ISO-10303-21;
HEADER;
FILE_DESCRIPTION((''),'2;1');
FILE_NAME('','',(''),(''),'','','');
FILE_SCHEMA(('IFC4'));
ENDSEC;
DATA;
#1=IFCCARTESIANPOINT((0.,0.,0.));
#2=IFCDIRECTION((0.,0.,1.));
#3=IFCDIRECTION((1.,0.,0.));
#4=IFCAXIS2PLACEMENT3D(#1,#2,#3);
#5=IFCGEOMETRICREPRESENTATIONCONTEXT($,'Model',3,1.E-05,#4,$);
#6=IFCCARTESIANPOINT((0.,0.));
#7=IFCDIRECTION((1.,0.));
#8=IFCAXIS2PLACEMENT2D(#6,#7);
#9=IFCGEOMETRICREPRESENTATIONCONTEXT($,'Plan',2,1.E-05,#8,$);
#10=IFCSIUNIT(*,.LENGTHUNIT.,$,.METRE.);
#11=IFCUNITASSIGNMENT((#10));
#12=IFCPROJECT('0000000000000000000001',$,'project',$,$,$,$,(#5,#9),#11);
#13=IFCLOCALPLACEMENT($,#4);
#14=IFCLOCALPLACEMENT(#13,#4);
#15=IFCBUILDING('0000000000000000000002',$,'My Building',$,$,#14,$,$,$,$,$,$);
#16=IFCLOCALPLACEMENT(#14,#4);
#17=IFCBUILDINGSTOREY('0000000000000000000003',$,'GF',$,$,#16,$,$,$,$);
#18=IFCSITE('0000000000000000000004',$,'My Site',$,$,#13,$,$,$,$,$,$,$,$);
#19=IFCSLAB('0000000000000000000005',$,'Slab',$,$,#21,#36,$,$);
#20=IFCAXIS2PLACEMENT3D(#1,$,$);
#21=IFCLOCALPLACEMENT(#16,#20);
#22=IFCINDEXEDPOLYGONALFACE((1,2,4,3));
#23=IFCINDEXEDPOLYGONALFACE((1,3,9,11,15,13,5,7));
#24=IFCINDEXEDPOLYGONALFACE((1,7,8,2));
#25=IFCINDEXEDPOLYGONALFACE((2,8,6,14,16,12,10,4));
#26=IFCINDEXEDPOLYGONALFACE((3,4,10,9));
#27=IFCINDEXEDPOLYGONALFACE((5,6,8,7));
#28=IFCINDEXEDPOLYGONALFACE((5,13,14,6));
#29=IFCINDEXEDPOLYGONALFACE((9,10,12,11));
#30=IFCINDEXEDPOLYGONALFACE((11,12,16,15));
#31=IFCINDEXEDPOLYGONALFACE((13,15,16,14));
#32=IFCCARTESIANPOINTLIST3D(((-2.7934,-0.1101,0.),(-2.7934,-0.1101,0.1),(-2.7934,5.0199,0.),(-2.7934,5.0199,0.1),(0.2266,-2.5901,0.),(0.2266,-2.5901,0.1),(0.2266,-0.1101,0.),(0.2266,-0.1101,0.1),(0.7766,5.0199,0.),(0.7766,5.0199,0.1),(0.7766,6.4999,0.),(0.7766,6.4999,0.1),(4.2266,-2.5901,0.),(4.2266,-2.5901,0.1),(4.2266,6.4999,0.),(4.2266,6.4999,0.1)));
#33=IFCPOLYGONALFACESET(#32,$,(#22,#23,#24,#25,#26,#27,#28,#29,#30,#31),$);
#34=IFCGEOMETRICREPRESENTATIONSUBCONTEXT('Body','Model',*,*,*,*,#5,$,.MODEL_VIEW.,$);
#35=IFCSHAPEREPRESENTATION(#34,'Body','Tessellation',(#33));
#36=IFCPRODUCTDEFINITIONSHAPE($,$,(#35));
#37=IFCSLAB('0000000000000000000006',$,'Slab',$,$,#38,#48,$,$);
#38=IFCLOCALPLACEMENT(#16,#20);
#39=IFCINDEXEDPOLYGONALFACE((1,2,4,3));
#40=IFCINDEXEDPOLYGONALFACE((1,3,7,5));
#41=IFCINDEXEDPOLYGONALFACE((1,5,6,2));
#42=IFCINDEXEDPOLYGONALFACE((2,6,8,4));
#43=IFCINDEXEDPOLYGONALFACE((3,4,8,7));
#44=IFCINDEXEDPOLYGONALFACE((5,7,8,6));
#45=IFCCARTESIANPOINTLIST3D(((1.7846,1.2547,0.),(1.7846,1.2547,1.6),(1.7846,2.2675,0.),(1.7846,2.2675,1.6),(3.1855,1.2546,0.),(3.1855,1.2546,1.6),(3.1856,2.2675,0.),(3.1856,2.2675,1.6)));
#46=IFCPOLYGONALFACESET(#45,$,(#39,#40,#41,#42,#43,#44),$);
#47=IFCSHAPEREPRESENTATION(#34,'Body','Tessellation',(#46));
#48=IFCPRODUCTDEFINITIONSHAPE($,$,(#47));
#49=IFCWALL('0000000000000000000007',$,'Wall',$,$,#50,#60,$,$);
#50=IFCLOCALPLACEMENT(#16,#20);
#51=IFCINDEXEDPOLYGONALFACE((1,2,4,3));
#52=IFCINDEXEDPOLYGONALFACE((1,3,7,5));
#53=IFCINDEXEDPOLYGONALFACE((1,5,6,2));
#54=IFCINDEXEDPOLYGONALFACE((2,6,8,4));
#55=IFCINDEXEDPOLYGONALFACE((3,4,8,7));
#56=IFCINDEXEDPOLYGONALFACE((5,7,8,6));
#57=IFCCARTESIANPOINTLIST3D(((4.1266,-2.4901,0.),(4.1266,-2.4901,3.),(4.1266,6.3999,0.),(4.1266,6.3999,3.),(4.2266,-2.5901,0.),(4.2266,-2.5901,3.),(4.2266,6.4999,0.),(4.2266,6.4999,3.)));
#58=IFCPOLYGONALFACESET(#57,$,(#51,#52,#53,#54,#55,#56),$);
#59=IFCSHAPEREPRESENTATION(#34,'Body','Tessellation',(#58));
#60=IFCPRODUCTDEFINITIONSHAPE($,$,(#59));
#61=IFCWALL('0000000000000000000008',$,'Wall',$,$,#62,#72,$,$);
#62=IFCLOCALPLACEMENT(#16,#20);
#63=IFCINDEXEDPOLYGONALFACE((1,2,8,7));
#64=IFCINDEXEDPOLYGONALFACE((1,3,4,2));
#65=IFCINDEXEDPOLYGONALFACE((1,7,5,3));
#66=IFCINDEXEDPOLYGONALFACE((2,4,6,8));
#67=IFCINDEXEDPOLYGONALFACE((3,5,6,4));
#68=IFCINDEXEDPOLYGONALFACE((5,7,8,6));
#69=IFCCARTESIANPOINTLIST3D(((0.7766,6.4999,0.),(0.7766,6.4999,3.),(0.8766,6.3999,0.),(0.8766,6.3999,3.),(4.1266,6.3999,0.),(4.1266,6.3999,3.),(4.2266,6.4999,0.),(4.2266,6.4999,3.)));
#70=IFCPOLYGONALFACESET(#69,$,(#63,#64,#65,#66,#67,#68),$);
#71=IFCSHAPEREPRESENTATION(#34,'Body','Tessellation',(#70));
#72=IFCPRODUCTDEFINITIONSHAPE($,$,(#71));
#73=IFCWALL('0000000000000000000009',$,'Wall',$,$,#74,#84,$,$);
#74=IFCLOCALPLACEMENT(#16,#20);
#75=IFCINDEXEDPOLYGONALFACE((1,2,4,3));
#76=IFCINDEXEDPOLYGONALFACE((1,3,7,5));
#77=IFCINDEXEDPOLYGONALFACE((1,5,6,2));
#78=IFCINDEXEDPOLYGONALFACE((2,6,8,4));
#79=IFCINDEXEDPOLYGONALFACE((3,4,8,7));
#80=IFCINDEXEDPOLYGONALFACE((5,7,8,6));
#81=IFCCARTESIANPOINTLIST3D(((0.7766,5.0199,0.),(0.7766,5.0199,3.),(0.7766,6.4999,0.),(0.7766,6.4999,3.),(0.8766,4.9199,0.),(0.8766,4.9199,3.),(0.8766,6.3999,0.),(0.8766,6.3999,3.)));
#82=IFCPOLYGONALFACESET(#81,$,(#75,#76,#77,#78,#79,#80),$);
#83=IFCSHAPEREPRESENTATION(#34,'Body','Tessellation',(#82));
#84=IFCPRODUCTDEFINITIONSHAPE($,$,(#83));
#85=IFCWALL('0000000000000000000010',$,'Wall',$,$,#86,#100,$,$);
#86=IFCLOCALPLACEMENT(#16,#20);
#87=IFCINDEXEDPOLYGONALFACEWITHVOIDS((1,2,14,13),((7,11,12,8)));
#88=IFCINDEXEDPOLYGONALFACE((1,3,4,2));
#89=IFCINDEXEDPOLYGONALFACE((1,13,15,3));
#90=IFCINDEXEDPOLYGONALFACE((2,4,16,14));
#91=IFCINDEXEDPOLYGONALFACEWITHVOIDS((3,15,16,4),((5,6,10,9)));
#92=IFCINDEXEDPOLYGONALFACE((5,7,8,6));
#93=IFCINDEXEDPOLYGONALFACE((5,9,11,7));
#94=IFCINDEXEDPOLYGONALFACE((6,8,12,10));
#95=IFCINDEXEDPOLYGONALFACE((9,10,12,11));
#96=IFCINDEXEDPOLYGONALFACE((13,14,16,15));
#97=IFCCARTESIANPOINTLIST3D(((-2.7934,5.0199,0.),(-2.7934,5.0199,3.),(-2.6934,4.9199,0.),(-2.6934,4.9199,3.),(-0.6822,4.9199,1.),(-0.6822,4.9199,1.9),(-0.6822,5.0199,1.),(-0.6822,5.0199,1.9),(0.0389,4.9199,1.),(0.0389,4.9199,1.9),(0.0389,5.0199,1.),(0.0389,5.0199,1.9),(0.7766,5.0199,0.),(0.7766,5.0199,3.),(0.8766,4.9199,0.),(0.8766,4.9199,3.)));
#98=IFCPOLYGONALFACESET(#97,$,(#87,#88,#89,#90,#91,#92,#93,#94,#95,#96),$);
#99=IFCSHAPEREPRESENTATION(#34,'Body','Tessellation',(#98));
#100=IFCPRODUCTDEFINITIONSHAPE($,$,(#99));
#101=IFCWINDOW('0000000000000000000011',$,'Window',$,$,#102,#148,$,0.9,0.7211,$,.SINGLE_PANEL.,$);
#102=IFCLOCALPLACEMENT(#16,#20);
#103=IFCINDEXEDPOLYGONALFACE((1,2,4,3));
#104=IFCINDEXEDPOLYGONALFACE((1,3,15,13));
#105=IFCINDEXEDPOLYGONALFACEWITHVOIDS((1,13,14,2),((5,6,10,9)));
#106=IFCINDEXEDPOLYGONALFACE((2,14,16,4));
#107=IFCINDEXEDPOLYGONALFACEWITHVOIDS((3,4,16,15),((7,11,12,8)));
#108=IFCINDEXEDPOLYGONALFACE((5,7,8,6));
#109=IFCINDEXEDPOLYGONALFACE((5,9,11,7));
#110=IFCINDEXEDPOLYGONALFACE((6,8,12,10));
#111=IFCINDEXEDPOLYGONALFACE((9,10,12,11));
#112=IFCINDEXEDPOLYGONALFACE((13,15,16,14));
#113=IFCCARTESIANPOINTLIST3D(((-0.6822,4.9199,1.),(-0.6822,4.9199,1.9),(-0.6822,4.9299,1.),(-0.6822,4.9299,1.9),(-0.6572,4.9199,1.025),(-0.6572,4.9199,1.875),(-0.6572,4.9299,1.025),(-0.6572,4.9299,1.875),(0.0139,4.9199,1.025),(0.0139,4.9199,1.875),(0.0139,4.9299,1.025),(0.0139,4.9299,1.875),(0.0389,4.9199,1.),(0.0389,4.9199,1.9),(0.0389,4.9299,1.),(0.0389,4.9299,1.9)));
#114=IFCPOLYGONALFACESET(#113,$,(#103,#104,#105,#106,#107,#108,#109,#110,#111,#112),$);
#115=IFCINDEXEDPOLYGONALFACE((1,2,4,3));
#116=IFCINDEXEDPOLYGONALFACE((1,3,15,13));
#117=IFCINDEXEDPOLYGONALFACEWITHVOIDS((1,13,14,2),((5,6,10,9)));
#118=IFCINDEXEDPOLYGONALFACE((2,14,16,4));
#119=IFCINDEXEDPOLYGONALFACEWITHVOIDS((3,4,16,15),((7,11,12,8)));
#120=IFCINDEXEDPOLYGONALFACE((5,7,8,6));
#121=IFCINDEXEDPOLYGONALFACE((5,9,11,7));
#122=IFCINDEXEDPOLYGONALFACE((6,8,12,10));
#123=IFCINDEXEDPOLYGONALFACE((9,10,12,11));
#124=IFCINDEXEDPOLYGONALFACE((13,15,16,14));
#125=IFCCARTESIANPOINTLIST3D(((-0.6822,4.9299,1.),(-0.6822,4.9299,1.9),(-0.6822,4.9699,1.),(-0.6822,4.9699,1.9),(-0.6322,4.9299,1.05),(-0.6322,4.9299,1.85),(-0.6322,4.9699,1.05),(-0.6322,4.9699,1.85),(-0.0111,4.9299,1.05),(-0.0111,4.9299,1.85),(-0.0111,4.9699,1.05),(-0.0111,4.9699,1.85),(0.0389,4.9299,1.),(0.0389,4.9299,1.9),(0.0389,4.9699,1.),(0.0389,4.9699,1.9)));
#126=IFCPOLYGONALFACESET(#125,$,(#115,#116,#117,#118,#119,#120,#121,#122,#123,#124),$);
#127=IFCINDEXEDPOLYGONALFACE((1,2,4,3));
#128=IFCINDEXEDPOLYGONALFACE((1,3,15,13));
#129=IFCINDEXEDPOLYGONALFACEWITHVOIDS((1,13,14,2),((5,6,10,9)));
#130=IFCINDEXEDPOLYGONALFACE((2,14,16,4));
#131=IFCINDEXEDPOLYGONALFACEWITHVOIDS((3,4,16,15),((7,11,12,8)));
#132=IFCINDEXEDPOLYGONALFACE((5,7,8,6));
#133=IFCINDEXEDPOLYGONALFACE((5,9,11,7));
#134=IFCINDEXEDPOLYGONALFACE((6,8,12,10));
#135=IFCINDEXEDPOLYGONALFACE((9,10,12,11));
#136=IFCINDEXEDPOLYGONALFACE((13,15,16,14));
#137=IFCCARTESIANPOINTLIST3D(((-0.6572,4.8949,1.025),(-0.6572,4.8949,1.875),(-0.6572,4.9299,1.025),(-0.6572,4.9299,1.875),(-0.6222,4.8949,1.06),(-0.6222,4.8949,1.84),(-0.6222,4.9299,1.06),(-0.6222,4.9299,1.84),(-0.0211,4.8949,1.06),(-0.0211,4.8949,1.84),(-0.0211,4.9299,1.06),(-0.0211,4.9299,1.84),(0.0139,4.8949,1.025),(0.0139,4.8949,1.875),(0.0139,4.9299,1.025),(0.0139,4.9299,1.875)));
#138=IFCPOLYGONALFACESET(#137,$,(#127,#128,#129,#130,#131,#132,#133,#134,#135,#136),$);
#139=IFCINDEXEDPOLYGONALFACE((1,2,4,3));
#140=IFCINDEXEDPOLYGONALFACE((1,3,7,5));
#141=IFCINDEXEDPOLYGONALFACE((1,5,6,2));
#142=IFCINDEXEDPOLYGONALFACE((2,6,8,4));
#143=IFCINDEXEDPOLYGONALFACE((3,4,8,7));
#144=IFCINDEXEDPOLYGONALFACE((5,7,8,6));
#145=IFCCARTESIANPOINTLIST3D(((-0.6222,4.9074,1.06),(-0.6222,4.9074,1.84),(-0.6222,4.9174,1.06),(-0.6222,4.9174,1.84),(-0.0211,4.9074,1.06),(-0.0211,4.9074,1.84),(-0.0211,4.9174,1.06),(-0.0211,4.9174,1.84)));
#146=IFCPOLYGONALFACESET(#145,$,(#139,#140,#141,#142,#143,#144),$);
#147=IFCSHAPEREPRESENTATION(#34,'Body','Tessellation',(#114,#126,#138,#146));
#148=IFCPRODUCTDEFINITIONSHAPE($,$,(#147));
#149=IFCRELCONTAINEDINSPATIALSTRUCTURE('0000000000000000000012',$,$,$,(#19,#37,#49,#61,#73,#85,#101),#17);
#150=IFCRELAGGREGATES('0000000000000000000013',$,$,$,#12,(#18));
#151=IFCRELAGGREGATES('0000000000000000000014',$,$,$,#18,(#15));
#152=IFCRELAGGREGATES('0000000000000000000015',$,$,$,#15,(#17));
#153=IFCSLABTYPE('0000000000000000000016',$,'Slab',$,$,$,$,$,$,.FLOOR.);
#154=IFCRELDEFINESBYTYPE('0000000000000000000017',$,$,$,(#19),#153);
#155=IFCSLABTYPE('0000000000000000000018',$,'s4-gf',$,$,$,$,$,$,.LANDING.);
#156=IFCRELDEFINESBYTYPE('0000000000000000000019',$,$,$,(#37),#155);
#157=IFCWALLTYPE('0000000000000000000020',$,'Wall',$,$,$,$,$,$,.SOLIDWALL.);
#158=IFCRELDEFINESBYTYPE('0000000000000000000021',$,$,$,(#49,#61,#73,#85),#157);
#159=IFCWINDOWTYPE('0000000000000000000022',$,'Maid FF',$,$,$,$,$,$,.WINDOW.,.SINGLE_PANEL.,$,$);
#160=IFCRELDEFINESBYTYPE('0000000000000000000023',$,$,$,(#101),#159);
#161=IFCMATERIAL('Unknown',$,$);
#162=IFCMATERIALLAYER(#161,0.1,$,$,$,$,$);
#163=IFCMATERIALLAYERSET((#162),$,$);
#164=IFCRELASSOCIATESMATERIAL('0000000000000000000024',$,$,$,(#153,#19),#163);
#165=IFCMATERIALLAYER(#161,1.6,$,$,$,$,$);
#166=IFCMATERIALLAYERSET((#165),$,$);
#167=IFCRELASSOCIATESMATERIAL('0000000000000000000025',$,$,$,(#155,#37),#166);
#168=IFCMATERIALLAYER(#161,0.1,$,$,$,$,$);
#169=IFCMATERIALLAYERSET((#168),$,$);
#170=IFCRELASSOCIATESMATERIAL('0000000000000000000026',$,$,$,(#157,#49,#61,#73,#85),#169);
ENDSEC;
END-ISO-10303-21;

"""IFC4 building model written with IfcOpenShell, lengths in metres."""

from ifc_helpers import new_model, entity, si_unit, frame, origin_with_axes, origin_2d_with_axis, place, context, subcontext, project, spatial, line, indexed_curve, outline, extrude, shape, source, transform, mapped, material, layer, layer_set, layer_usage, type_object, type_shapes, element, fill, save


model = new_model("IFC4")

# Units and contexts
model_context = context("Model", 3, precision=1e-05, world=origin_with_axes())
plan_context = context("Plan", 2, precision=1e-05, world=origin_2d_with_axis())
body_context_1 = subcontext(model_context, "Body", "Model", "MODEL_VIEW")
body_context_2 = subcontext(plan_context, "Body", "Plan", "PLAN_VIEW")
ifc_project = project(units=[si_unit("LENGTHUNIT", "METRE")], contexts=[model_context, plan_context])

# Site, building, storey
site_placement = place(None, origin_with_axes())
site = spatial("IfcSite", under=ifc_project, at=site_placement, Name="My Site")
building_placement = place(site_placement, origin_with_axes())
building = spatial("IfcBuilding", under=site, at=building_placement, Name="My Building")
storey_placement = place(building_placement, origin_with_axes())
storey = spatial("IfcBuildingStorey", under=building, at=storey_placement, Name="GF")

# Slabs
ifc_material_1 = material(Name="Unknown")
ifc_layer_1 = layer(ifc_material_1, 0.1)
ifc_layer_set_1 = layer_set([ifc_layer_1])
ifc_layer_usage_1 = layer_usage(ifc_layer_set_1, "AXIS3", "POSITIVE", -0.1)
slab_type_1 = type_object("IfcSlabType", Name="Slab", PredefinedType="FLOOR", material=ifc_layer_set_1)
slab_1_placement = place(storey_placement, frame((4.2266, -2.5901, 0.1), z_axis=(0.0, 0.0, 1.0), x_axis=(1.0, 0.0, 0.0)))
element("IfcSlab", 1, at=slab_1_placement, inside=storey, type_object=slab_type_1, material=ifc_layer_usage_1, Name="Slab", context=body_context_1, shape_type="SweptSolid", body=[
    extrude(outline(indexed_curve([(0.0, 0.0), (-4.0, 0.0), (-4.0, 2.48), (-7.02, 2.48), (-7.02, 7.61), (-3.45, 7.61), (-3.45, 9.09), (0.0, 9.09), (0.0, 0.0)])), frame((0.0, 0.0, -0.1), z_axis=(0.0, 0.0, 1.0), x_axis=(1.0, 0.0, 0.0)), (0.0, 0.0, 1.0), 0.1),
])
ifc_layer_2 = layer(ifc_material_1, 1.6)
ifc_layer_set_2 = layer_set([ifc_layer_2])
ifc_layer_usage_2 = layer_usage(ifc_layer_set_2, "AXIS3", "POSITIVE", -1.8)
slab_type_2 = type_object("IfcSlabType", Name="s4-gf", PredefinedType="LANDING", material=ifc_layer_set_2)
slab_2_placement = place(storey_placement, frame((3.1855, 1.2546, 1.8), z_axis=(0.0, 0.0, 1.0), x_axis=(1.0, 0.0, 0.0)))
element("IfcSlab", 2, at=slab_2_placement, inside=storey, type_object=slab_type_2, material=ifc_layer_usage_2, Name="Slab", context=body_context_1, shape_type="SweptSolid", body=[
    extrude(outline(indexed_curve([(0.0001, 1.0128), (-1.401, 1.0128), (-1.4009, 0.0001), (0.0, 0.0), (0.0001, 1.0128)])), frame((0.0, 0.0, -1.8), z_axis=(0.0, 0.0, 1.0), x_axis=(1.0, 0.0, 0.0)), (0.0, 0.0, 1.0), 1.6),
])

# Shared definitions
ifc_layer_3 = layer(ifc_material_1, 0.1)
ifc_layer_set_3 = layer_set([ifc_layer_3])
wall_type = type_object("IfcWallType", Name="Wall", PredefinedType="SOLIDWALL", material=ifc_layer_set_3)

# Walls
ifc_layer_usage_3 = layer_usage(ifc_layer_set_3, "AXIS2", "POSITIVE", 0.0)
wall_1_placement = place(storey_placement, frame((4.2266, -2.5901, 0.0), z_axis=(0.0, 0.0, 1.0), x_axis=(0.0, 1.0, 0.0)))
element("IfcWall", 3, at=wall_1_placement, inside=storey, type_object=wall_type, material=ifc_layer_usage_3, Name="Wall", context=body_context_1, shape_type="SweptSolid", body=[
    extrude(outline(indexed_curve([(0.0, 0.0), (0.1, 0.1), (8.99, 0.1), (9.09, 0.0)], segments=[line(1, 2, 3, 4, 1)])), origin_with_axes(), (0.0, 0.0, 1.0), 3.0),
])
ifc_layer_usage_4 = layer_usage(ifc_layer_set_3, "AXIS2", "POSITIVE", 0.0)
wall_2_placement = place(storey_placement, frame((4.2266, 6.4999, 0.0), z_axis=(0.0, 0.0, 1.0), x_axis=(-1.0, 0.0, 0.0)))
element("IfcWall", 4, at=wall_2_placement, inside=storey, type_object=wall_type, material=ifc_layer_usage_4, Name="Wall", context=body_context_1, shape_type="SweptSolid", body=[
    extrude(outline(indexed_curve([(0.0, 0.0), (0.1, 0.1), (3.35, 0.1), (3.45, 0.0)], segments=[line(1, 2, 3, 4, 1)])), origin_with_axes(), (0.0, 0.0, 1.0), 3.0),
])
ifc_layer_usage_5 = layer_usage(ifc_layer_set_3, "AXIS2", "POSITIVE", 0.0)
wall_3_placement = place(storey_placement, frame((0.7766, 6.4999, 0.0), z_axis=(0.0, 0.0, 1.0), x_axis=(0.0, -1.0, 0.0)))
element("IfcWall", 5, at=wall_3_placement, inside=storey, type_object=wall_type, material=ifc_layer_usage_5, Name="Wall", context=body_context_1, shape_type="SweptSolid", body=[
    extrude(outline(indexed_curve([(0.0, 0.0), (0.1, 0.1), (1.58, 0.1), (1.48, 0.0)], segments=[line(1, 2, 3, 4, 1)])), origin_with_axes(), (0.0, 0.0, 1.0), 3.0),
])

# Wall, opening, window
ifc_layer_usage_6 = layer_usage(ifc_layer_set_3, "AXIS2", "POSITIVE", 0.0)
wall_4_placement = place(storey_placement, frame((0.7766, 5.0199, 0.0), z_axis=(0.0, 0.0, 1.0), x_axis=(-1.0, 0.0, 0.0)))
wall_4 = element("IfcWall", 6, at=wall_4_placement, inside=storey, type_object=wall_type, material=ifc_layer_usage_6, Name="Wall", context=body_context_1, shape_type="SweptSolid", body=[
    extrude(outline(indexed_curve([(0.0, 0.0), (-0.1, 0.1), (3.47, 0.1), (3.57, 0.0)], segments=[line(1, 2, 3, 4, 1)])), origin_with_axes(), (0.0, 0.0, 1.0), 3.0),
])
shared_shape_1 = source(origin_with_axes(), body_context_1, "Body", "SweptSolid", [
    extrude(outline(indexed_curve([(0.0, 0.0), (0.7211, 0.0), (0.7211, 0.9), (0.0, 0.9)], segments=[line(1, 2, 3, 4, 1)])), frame((0.0, -0.6, 0.0), z_axis=(0.0, -1.0, 0.0), x_axis=(1.0, 0.0, 0.0)), (0.0, 0.0, -1.0), 1.2),
])
opening_1_placement = place(wall_4_placement, frame((0.7377, 0.0, 1.0), z_axis=(0.0, 0.0, 1.0), x_axis=(1.0, 0.0, 0.0)))
opening_1 = element("IfcOpeningElement", 7, at=opening_1_placement, cuts=wall_4, PredefinedType="OPENING", context=body_context_1, shape_type="MappedRepresentation", body=[
    mapped(shared_shape_1, transform((0.0, 0.0, 0.0), x_axis=(1.0, 0.0, 0.0), y_axis=(0.0, 1.0, 0.0), z_axis=(0.0, 0.0, 1.0), scale=1.0)),
])
window_type_1 = type_object("IfcWindowType", Name="Maid FF", PartitioningType="SINGLE_PANEL", PredefinedType="WINDOW")
shared_shape_2 = source(origin_with_axes(), body_context_1, "Body", "SweptSolid", [
    extrude(outline(indexed_curve([(0.0, 0.0), (0.7211, 0.0), (0.7211, 0.9), (0.0, 0.9)], segments=[line(1, 2, 3, 4, 1)]), holes=[indexed_curve([(0.025, 0.025), (0.6961, 0.025), (0.6961, 0.875), (0.025, 0.875)], segments=[line(1, 2, 3, 4, 1)])]), frame((0.0, 0.09, 0.0), z_axis=(0.0, -1.0, 0.0), x_axis=(1.0, 0.0, 0.0)), (0.0, 0.0, -1.0), 0.01),
    extrude(outline(indexed_curve([(0.0, 0.0), (0.7211, 0.0), (0.7211, 0.9), (0.0, 0.9)], segments=[line(1, 2, 3, 4, 1)]), holes=[indexed_curve([(0.05, 0.05), (0.6711, 0.05), (0.6711, 0.85), (0.05, 0.85)], segments=[line(1, 2, 3, 4, 1)])]), frame((0.0, 0.05, 0.0), z_axis=(0.0, -1.0, 0.0), x_axis=(1.0, 0.0, 0.0)), (0.0, 0.0, -1.0), 0.04),
    extrude(outline(indexed_curve([(0.0, 0.0), (0.6711, 0.0), (0.6711, 0.85), (0.0, 0.85)], segments=[line(1, 2, 3, 4, 1)]), holes=[indexed_curve([(0.035, 0.035), (0.6361, 0.035), (0.6361, 0.815), (0.035, 0.815)], segments=[line(1, 2, 3, 4, 1)])]), frame((0.025, 0.09, 0.025), z_axis=(0.0, -1.0, 0.0), x_axis=(1.0, 0.0, 0.0)), (0.0, 0.0, -1.0), 0.035),
    extrude(outline(indexed_curve([(0.035, 0.035), (0.6361, 0.035), (0.6361, 0.815), (0.035, 0.815)], segments=[line(1, 2, 3, 4, 1)])), frame((0.025, 0.1025, 0.025), z_axis=(0.0, -1.0, 0.0), x_axis=(1.0, 0.0, 0.0)), (0.0, 0.0, -1.0), 0.01),
])
shared_shape_3 = source(origin_with_axes(), body_context_2, "Body", "Curve2D", [
    entity("IfcIndexedPolyCurve", entity("IfcCartesianPointList2D", [[0.05, 0.05], [0.6711, 0.05]])),
    entity("IfcIndexedPolyCurve", entity("IfcCartesianPointList2D", [[0.0, 0.1], [0.025, 0.1], [0.025, 0.09], [0.05, 0.09], [0.05, 0.05], [0.0, 0.05]]), [entity("IfcLineIndex", [1, 2, 3, 4, 5, 6, 1])]),
    entity("IfcIndexedPolyCurve", entity("IfcCartesianPointList2D", [[0.7211, 0.1], [0.6961, 0.1], [0.6961, 0.09], [0.6711, 0.09], [0.6711, 0.05], [0.7211, 0.05]]), [entity("IfcLineIndex", [1, 2, 3, 4, 5, 6, 1])]),
    entity("IfcIndexedPolyCurve", entity("IfcCartesianPointList2D", [[0.025, 0.09], [0.06, 0.09], [0.06, 0.125], [0.025, 0.125]]), [entity("IfcLineIndex", [1, 2, 3, 4, 1])]),
    entity("IfcIndexedPolyCurve", entity("IfcCartesianPointList2D", [[0.6961, 0.09], [0.6611, 0.09], [0.6611, 0.125], [0.6961, 0.125]]), [entity("IfcLineIndex", [1, 2, 3, 4, 1])]),
    entity("IfcIndexedPolyCurve", entity("IfcCartesianPointList2D", [[0.06, 0.09], [0.6611, 0.09]])),
    entity("IfcIndexedPolyCurve", entity("IfcCartesianPointList2D", [[0.06, 0.125], [0.6611, 0.125]])),
    entity("IfcIndexedPolyCurve", entity("IfcCartesianPointList2D", [[0.06, 0.1075], [0.6611, 0.1075]])),
])
type_shapes(window_type_1, [shared_shape_2, shared_shape_3])
window_1_placement = place(opening_1_placement, frame((0.0, 0.0, 0.0), z_axis=(0.0, 0.0, 1.0), x_axis=(1.0, 0.0, 0.0)))
window_1 = element("IfcWindow", 8, at=window_1_placement, inside=storey, type_object=window_type_1, Name="Window", OverallHeight=0.9, OverallWidth=0.7211, PartitioningType="SINGLE_PANEL", shapes=[
    shape(body_context_1, "Body", "MappedRepresentation", [mapped(shared_shape_2, transform((0.0, 0.0, 0.0), x_axis=(1.0, 0.0, 0.0), y_axis=(0.0, 1.0, 0.0), z_axis=(0.0, 0.0, 1.0), scale=1.0))]),
    shape(body_context_2, "Body", "MappedRepresentation", [mapped(shared_shape_3, transform((0.0, 0.0, 0.0), x_axis=(1.0, 0.0, 0.0), y_axis=(0.0, 1.0, 0.0), z_axis=(0.0, 0.0, 1.0), scale=1.0))]),
])
fill(opening_1, window_1)

save(model, "model.ifc")
